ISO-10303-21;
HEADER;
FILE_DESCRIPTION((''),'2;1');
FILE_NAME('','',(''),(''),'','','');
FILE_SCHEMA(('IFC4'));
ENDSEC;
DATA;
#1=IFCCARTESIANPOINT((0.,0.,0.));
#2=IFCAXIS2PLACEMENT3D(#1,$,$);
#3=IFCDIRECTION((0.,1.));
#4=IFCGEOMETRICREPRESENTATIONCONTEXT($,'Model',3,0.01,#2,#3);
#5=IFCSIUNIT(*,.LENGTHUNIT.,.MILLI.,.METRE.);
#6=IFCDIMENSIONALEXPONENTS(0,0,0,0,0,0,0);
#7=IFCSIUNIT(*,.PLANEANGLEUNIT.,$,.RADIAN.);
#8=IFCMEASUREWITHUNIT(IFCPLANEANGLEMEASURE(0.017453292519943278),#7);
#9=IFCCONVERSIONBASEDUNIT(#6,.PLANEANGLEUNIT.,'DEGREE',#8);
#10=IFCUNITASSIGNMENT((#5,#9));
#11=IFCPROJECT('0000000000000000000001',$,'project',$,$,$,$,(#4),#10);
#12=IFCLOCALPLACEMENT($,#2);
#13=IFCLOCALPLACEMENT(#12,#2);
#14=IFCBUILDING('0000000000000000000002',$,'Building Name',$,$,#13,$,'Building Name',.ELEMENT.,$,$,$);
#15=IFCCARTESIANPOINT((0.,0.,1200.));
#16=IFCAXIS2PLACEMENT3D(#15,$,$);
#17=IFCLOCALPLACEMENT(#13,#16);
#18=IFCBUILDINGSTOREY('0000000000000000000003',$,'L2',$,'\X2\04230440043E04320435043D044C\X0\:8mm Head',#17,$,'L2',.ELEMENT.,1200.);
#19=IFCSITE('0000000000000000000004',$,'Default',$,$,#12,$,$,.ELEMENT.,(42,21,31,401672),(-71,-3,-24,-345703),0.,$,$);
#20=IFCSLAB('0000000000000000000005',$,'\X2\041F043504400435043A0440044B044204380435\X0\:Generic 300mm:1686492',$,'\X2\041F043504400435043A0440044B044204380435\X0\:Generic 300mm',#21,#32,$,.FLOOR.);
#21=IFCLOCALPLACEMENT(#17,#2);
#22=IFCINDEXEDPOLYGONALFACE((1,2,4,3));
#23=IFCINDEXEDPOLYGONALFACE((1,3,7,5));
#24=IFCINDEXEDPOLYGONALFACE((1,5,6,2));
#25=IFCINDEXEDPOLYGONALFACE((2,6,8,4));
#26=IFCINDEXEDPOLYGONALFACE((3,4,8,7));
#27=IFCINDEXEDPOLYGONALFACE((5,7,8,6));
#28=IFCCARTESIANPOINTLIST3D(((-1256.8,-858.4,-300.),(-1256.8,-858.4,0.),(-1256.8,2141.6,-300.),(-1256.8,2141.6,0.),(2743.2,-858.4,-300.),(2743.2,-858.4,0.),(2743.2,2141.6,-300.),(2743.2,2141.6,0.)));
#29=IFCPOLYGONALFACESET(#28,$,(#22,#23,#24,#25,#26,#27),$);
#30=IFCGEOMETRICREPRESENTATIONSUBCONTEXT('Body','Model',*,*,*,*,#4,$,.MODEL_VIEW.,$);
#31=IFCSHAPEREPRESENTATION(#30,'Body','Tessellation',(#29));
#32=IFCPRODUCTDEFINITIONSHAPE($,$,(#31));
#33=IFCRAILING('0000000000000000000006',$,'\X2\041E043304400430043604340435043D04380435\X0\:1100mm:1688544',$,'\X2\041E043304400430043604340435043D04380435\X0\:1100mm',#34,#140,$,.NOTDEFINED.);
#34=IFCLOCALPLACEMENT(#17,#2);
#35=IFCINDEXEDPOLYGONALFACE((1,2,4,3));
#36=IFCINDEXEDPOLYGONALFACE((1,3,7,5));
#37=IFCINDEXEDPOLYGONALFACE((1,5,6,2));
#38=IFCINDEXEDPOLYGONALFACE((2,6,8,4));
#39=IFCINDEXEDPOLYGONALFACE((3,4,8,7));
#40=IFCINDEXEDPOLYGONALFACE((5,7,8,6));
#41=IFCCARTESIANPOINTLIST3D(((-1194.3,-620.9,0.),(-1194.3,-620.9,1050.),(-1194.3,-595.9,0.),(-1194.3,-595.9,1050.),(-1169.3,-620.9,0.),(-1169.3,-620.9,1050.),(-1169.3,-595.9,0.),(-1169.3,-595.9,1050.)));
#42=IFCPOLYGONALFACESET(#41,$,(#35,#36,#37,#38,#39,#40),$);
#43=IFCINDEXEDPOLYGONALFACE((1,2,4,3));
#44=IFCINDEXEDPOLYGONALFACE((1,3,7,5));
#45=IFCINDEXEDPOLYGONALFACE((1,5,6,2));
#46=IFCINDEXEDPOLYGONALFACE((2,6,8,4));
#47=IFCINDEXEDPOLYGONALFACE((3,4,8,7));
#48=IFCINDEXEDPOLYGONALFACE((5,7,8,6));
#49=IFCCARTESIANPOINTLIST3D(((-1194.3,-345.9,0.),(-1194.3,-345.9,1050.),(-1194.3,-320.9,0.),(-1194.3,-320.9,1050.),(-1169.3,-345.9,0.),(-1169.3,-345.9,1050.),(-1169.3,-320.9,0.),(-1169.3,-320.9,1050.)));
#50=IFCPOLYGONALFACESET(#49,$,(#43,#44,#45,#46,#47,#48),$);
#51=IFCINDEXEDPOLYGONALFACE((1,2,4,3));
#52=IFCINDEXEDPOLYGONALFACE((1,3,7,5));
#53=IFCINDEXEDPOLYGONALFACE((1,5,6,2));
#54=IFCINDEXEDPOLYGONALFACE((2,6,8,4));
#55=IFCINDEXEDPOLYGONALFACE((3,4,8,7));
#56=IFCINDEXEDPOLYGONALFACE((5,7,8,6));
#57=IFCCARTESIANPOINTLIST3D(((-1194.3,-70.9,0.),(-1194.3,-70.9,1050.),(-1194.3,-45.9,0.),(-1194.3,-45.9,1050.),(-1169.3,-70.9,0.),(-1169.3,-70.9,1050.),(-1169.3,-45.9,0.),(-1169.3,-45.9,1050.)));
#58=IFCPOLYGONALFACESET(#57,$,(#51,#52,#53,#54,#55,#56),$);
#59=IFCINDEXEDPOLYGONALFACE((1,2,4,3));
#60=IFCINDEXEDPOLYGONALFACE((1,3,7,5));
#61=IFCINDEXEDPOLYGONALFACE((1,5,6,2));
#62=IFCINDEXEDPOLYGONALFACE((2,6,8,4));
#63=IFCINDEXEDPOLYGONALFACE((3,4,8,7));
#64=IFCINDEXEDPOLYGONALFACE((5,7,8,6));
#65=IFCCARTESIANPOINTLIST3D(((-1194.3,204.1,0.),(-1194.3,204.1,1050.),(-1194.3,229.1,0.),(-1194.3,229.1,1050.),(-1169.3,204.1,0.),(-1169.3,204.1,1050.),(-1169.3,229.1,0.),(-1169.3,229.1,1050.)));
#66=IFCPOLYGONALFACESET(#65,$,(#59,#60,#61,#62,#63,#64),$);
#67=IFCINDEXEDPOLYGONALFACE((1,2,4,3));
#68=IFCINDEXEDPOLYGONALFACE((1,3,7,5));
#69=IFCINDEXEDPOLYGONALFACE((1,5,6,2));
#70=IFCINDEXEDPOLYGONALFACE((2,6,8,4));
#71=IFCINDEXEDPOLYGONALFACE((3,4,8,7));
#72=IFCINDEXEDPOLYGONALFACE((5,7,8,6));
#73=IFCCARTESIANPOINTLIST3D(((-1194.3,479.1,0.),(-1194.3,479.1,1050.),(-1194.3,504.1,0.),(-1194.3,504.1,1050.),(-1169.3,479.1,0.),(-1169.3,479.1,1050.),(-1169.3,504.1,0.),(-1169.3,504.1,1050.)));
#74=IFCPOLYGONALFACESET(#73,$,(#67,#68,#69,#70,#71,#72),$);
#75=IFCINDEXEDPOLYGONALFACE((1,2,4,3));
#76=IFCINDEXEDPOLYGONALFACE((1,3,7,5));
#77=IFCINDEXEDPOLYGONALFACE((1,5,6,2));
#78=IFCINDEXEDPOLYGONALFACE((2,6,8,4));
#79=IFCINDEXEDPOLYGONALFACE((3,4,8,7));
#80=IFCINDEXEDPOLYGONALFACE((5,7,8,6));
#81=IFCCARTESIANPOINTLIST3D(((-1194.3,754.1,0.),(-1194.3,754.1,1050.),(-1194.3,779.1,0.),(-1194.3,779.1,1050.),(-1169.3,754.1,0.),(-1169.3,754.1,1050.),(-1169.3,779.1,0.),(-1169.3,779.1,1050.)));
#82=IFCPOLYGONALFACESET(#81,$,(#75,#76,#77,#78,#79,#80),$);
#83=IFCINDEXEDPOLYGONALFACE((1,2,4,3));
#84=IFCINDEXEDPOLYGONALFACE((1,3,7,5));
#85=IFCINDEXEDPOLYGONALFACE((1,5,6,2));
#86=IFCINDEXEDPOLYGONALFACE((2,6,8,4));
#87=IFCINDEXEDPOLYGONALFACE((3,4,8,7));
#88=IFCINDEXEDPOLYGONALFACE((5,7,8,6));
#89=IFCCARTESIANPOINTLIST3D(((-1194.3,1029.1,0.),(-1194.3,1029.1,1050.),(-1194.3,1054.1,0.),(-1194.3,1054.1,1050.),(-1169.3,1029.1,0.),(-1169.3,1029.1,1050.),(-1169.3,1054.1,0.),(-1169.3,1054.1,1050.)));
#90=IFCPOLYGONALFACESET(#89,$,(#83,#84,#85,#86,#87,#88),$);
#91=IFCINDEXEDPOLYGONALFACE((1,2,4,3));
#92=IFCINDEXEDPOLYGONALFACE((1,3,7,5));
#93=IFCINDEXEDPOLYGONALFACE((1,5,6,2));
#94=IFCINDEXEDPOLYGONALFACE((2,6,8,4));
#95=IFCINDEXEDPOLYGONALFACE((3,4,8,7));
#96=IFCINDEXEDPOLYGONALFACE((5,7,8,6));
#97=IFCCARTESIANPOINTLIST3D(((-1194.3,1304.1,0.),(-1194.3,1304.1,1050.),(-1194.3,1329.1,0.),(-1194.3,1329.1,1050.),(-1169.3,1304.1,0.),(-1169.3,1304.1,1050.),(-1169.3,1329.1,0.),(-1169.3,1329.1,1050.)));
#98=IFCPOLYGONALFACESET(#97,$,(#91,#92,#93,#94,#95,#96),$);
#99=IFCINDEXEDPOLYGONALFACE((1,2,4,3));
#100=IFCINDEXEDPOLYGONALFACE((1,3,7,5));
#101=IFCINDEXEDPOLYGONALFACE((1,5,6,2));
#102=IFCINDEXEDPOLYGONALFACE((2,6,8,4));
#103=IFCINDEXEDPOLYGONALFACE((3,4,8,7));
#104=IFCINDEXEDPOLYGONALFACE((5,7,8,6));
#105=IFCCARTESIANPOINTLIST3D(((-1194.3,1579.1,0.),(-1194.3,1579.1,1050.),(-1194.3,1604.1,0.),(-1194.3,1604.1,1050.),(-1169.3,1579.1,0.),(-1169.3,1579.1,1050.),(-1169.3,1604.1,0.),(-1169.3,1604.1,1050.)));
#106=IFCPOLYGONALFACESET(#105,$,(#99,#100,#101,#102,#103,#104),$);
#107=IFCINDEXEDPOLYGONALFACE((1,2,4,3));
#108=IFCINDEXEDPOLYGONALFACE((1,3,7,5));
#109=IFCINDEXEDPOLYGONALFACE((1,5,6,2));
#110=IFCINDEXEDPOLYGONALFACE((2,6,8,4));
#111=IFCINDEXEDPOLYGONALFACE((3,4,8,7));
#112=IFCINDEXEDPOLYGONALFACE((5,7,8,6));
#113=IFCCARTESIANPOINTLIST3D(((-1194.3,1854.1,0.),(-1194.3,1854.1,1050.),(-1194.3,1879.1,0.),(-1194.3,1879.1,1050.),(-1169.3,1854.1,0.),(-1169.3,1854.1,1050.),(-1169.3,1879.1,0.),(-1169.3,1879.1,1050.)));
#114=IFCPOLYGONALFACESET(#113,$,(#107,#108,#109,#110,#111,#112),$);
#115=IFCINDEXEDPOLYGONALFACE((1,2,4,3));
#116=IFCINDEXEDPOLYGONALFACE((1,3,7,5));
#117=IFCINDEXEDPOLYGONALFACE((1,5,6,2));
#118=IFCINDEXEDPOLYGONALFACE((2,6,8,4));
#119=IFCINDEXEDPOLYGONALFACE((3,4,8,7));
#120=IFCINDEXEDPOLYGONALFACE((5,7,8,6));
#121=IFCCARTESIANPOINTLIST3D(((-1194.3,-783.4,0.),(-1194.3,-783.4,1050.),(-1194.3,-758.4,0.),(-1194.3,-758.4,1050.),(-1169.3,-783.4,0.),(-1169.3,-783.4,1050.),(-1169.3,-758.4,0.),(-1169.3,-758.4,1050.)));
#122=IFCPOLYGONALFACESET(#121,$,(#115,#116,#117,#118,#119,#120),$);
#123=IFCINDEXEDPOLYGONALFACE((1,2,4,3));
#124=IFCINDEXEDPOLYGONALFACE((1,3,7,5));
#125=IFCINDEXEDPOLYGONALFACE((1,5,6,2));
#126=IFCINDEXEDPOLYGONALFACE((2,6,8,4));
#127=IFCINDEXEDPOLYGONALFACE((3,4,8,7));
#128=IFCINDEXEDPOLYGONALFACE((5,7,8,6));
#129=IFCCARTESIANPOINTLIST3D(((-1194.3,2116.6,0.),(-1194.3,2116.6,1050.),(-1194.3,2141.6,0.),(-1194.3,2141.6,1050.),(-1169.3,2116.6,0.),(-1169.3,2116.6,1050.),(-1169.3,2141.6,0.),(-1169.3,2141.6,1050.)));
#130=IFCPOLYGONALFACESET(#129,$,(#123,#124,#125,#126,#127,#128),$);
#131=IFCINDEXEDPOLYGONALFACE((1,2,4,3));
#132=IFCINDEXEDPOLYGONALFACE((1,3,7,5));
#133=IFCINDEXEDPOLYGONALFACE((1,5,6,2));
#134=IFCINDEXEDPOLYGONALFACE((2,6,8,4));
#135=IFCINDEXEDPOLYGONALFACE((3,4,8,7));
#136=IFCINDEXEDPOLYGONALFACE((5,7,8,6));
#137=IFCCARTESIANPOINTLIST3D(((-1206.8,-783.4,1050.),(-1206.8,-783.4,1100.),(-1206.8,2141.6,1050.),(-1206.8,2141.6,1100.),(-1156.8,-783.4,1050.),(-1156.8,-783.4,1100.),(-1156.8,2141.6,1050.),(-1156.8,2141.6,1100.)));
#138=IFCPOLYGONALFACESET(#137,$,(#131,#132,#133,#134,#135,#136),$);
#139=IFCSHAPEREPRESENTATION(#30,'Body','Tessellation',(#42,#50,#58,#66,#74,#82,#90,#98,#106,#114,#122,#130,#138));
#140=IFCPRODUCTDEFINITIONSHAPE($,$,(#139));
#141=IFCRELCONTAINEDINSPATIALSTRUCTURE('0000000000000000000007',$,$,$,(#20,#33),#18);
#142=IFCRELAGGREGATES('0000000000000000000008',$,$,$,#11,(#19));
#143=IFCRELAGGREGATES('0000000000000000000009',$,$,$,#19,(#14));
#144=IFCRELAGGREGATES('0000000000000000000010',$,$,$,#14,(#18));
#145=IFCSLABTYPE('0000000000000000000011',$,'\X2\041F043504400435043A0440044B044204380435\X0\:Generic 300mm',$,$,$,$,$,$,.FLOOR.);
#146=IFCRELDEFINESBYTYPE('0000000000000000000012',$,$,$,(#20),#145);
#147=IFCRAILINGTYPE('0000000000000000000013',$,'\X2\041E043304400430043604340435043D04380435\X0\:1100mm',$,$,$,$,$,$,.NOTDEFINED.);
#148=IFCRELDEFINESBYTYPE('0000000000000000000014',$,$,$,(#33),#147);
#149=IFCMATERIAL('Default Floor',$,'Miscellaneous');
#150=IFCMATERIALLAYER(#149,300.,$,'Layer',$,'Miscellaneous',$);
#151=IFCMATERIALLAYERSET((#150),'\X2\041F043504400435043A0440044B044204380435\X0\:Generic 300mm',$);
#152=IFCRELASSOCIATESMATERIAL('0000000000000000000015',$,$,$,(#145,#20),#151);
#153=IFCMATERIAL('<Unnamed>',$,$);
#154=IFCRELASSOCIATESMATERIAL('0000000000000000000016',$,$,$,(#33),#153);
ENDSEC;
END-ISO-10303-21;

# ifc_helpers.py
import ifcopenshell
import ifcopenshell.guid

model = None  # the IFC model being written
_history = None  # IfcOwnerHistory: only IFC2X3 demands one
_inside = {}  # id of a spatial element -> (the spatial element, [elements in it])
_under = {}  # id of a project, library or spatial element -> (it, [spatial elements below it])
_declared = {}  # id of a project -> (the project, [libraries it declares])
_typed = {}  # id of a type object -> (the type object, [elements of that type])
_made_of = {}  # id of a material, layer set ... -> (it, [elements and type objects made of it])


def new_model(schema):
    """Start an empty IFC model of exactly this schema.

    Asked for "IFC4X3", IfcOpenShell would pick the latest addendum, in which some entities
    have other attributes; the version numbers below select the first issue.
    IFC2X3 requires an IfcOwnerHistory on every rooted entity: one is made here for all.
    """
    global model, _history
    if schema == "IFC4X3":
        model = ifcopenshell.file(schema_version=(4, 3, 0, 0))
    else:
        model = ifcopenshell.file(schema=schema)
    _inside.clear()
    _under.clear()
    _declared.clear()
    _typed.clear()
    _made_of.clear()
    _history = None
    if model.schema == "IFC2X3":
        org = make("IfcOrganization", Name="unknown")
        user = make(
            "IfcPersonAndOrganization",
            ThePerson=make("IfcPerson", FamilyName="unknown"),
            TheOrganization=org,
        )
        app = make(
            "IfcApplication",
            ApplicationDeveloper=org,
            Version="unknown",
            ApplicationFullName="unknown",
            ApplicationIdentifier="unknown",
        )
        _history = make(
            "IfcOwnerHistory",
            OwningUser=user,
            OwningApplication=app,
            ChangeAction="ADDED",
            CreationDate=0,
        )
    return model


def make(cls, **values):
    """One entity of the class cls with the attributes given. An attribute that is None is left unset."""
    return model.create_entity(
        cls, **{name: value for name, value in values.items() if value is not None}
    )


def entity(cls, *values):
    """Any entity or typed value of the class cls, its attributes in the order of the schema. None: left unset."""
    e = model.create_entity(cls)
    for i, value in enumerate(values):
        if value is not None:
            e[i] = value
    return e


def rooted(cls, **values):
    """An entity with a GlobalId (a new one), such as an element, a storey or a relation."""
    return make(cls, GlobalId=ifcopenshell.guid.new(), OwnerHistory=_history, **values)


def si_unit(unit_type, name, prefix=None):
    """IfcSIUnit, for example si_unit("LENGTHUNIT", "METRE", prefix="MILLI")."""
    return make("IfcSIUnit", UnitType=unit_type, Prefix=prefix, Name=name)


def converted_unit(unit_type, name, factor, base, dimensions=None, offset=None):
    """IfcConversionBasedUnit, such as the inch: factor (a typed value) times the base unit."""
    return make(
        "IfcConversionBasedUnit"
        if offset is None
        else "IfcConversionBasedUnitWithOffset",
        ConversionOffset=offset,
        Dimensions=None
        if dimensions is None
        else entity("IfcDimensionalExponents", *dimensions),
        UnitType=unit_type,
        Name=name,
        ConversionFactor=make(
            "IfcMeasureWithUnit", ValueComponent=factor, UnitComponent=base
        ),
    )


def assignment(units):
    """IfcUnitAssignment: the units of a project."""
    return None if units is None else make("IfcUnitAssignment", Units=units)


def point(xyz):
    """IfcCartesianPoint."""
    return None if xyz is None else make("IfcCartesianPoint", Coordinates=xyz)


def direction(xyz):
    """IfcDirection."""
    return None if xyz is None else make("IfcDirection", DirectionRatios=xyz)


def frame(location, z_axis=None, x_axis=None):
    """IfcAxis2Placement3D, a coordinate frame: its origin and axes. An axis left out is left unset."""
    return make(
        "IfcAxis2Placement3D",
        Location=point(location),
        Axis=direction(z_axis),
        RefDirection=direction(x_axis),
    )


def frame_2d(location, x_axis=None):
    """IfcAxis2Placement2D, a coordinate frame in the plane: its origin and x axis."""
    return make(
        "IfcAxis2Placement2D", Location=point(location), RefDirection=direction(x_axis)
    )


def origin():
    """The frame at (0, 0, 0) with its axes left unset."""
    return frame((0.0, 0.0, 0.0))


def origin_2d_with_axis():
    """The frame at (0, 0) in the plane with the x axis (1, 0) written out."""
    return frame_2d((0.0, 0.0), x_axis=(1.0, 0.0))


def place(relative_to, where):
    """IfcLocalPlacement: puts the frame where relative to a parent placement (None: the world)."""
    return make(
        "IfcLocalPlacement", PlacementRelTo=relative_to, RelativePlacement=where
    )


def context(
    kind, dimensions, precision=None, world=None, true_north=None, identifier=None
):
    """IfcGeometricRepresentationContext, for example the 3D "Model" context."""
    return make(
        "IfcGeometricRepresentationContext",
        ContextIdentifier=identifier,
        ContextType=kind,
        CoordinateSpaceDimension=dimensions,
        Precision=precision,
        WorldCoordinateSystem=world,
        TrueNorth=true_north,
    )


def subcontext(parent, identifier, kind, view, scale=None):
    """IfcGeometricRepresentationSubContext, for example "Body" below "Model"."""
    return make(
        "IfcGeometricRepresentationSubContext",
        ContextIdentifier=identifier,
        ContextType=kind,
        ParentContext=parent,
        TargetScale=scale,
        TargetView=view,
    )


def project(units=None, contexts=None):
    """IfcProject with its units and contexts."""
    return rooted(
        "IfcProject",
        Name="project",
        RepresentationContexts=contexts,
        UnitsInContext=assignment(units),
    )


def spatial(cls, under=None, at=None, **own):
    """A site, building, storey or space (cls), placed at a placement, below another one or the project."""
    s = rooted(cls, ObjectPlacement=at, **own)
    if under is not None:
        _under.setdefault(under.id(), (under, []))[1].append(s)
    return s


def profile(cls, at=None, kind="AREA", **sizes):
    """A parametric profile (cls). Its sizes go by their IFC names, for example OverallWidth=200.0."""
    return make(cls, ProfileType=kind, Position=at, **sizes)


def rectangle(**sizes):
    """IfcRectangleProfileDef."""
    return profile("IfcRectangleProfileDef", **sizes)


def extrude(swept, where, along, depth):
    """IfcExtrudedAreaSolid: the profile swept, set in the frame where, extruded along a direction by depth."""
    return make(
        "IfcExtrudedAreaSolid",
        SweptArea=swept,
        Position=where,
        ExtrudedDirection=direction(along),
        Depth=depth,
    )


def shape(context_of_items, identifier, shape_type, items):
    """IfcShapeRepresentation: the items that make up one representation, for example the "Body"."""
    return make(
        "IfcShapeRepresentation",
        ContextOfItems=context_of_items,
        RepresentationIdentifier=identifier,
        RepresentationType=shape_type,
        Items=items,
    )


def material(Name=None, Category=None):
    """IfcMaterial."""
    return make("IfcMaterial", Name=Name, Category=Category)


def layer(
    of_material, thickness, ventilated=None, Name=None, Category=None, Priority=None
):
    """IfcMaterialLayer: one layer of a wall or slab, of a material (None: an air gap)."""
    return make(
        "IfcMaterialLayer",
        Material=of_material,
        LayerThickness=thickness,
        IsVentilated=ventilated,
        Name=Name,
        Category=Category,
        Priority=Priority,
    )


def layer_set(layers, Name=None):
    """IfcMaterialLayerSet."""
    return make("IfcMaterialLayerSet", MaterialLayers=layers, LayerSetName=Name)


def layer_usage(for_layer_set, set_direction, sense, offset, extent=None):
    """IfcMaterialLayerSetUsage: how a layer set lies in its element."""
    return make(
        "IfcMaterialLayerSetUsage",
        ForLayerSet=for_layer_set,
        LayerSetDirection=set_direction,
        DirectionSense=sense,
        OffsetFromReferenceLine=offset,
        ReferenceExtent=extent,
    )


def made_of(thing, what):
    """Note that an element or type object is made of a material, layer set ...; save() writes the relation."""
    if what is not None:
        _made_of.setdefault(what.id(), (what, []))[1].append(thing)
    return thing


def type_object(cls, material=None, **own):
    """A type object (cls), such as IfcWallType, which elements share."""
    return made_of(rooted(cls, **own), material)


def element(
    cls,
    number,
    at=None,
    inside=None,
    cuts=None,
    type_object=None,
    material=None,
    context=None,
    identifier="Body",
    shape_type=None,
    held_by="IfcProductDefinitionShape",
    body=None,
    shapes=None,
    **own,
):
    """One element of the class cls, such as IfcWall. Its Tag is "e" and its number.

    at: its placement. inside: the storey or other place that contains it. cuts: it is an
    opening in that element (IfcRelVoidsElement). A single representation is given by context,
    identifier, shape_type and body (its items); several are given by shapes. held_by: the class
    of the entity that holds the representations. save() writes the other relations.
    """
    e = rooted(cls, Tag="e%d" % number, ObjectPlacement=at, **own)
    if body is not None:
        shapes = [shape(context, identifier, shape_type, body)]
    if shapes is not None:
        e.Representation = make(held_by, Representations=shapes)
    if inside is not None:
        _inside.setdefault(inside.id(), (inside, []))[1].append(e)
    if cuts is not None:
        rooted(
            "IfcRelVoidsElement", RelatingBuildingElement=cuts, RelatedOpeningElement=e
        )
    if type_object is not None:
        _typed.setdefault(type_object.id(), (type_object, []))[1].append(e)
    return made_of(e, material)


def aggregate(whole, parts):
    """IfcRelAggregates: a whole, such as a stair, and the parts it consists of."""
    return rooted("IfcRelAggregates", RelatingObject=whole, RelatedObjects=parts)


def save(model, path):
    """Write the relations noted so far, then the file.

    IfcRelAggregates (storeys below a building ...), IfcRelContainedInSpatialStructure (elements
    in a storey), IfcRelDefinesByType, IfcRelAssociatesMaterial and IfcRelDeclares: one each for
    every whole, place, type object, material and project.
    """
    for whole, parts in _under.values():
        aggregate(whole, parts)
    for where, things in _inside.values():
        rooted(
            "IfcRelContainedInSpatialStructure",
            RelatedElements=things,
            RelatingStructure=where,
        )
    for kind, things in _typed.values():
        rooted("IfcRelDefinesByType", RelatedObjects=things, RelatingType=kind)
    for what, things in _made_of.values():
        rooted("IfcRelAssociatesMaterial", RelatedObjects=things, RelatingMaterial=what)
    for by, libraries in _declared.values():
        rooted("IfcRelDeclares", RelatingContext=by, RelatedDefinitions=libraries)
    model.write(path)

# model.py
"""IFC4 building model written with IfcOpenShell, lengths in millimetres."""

from ifc_helpers import new_model, entity, si_unit, converted_unit, direction, frame, frame_2d, origin, origin_2d_with_axis, place, context, subcontext, project, spatial, rectangle, extrude, material, layer, layer_set, layer_usage, type_object, element, save


model = new_model("IFC4")

# Units and contexts
model_context = context("Model", 3, precision=0.01, world=origin(), true_north=direction((0.0, 1.0)))
body_context = subcontext(model_context, "Body", "Model", "MODEL_VIEW")
ifc_project = project(units=[si_unit("LENGTHUNIT", "METRE", prefix="MILLI"), converted_unit("PLANEANGLEUNIT", "DEGREE", entity("IfcPlaneAngleMeasure", 0.017453292519943278), si_unit("PLANEANGLEUNIT", "RADIAN"), dimensions=[0, 0, 0, 0, 0, 0, 0])], contexts=[model_context])

# Site, building, storey
site_placement = place(None, origin())
site = spatial("IfcSite", under=ifc_project, at=site_placement, Name="Default", CompositionType="ELEMENT", RefLatitude=(42, 21, 31, 401672), RefLongitude=(-71, -3, -24, -345703), RefElevation=0.0)
building_placement = place(site_placement, origin())
building = spatial("IfcBuilding", under=site, at=building_placement, Name="Building Name", LongName="Building Name", CompositionType="ELEMENT")
storey_placement = place(building_placement, frame((0.0, 0.0, 1200.0)))
storey = spatial("IfcBuildingStorey", under=building, at=storey_placement, Name="L2", ObjectType="Уровень:8mm Head", LongName="L2", CompositionType="ELEMENT", Elevation=1200.0)

# Slab
ifc_material_1 = material(Name="Default Floor", Category="Miscellaneous")
ifc_layer = layer(ifc_material_1, 300.0, Name="Layer", Category="Miscellaneous")
ifc_layer_set = layer_set([ifc_layer], Name="Перекрытие:Generic 300mm")
ifc_layer_usage = layer_usage(ifc_layer_set, "AXIS3", "POSITIVE", 0.0)
slab_type = type_object("IfcSlabType", Name="Перекрытие:Generic 300mm", PredefinedType="FLOOR", material=ifc_layer_set)
slab_placement = place(storey_placement, origin())
element("IfcSlab", 1, at=slab_placement, inside=storey, type_object=slab_type, material=ifc_layer_usage, Name="Перекрытие:Generic 300mm:1686492", ObjectType="Перекрытие:Generic 300mm", PredefinedType="FLOOR", context=body_context, shape_type="SweptSolid", body=[
    extrude(rectangle(XDim=3000.0, YDim=4000.0, at=origin_2d_with_axis()), frame((743.2, 641.6, 0.0), z_axis=(0.0, 0.0, -1.0), x_axis=(0.0, 1.0, 0.0)), (0.0, 0.0, 1.0), 300.0),
])

# Railing
ifc_material_2 = material(Name="<Unnamed>")
railing_type = type_object("IfcRailingType", Name="Ограждение:1100mm", PredefinedType="NOTDEFINED")
railing_1_placement = place(storey_placement, frame((-1206.8, -783.4, 0.0)))
element("IfcRailing", 2, at=railing_1_placement, inside=storey, type_object=railing_type, material=ifc_material_2, Name="Ограждение:1100mm:1688544", ObjectType="Ограждение:1100mm", PredefinedType="NOTDEFINED", context=body_context, shape_type="SweptSolid", body=[
    extrude(rectangle(XDim=25.0, YDim=25.0, at=frame_2d((0.0, 0.0), x_axis=(1.0, 0.0))), frame((25.0, 175.0, 0.0), z_axis=(0.0, 0.0, 1.0), x_axis=(0.0, -1.0, 0.0)), (0.0, 0.0, 1.0), 1050.0),
    extrude(rectangle(XDim=25.0, YDim=25.0, at=origin_2d_with_axis()), frame((25.0, 450.0, 0.0), z_axis=(0.0, 0.0, 1.0), x_axis=(0.0, -1.0, 0.0)), (0.0, 0.0, 1.0), 1050.0),
    extrude(rectangle(XDim=25.0, YDim=25.0, at=origin_2d_with_axis()), frame((25.0, 725.0, 0.0), z_axis=(0.0, 0.0, 1.0), x_axis=(0.0, -1.0, 0.0)), (0.0, 0.0, 1.0), 1050.0),
    extrude(rectangle(XDim=25.0, YDim=25.0, at=origin_2d_with_axis()), frame((25.0, 1000.0, 0.0), z_axis=(0.0, 0.0, 1.0), x_axis=(0.0, -1.0, 0.0)), (0.0, 0.0, 1.0), 1050.0),
    extrude(rectangle(XDim=25.0, YDim=25.0, at=origin_2d_with_axis()), frame((25.0, 1275.0, 0.0), z_axis=(0.0, 0.0, 1.0), x_axis=(0.0, -1.0, 0.0)), (0.0, 0.0, 1.0), 1050.0),
    extrude(rectangle(XDim=25.0, YDim=25.0, at=origin_2d_with_axis()), frame((25.0, 1550.0, 0.0), z_axis=(0.0, 0.0, 1.0), x_axis=(0.0, -1.0, 0.0)), (0.0, 0.0, 1.0), 1050.0),
    extrude(rectangle(XDim=25.0, YDim=25.0, at=frame_2d((0.0, 0.0), x_axis=(1.0, 0.0))), frame((25.0, 1825.0, 0.0), z_axis=(0.0, 0.0, 1.0), x_axis=(0.0, -1.0, 0.0)), (0.0, 0.0, 1.0), 1050.0),
    extrude(rectangle(XDim=25.0, YDim=25.0, at=origin_2d_with_axis()), frame((25.0, 2100.0, 0.0), z_axis=(0.0, 0.0, 1.0), x_axis=(0.0, -1.0, 0.0)), (0.0, 0.0, 1.0), 1050.0),
    extrude(rectangle(XDim=25.0, YDim=25.0, at=origin_2d_with_axis()), frame((25.0, 2375.0, 0.0), z_axis=(0.0, 0.0, 1.0), x_axis=(0.0, -1.0, 0.0)), (0.0, 0.0, 1.0), 1050.0),
    extrude(rectangle(XDim=25.0, YDim=25.0, at=origin_2d_with_axis()), frame((25.0, 2650.0, 0.0), z_axis=(0.0, 0.0, 1.0), x_axis=(0.0, -1.0, 0.0)), (0.0, 0.0, 1.0), 1050.0),
    extrude(rectangle(XDim=25.0, YDim=25.0, at=origin_2d_with_axis()), frame((25.0, 12.5, 0.0), z_axis=(0.0, 0.0, 1.0), x_axis=(0.0, -1.0, 0.0)), (0.0, 0.0, 1.0), 1050.0),
    extrude(rectangle(XDim=25.0, YDim=25.0, at=origin_2d_with_axis()), frame((25.0, 2912.5, 0.0), z_axis=(0.0, 0.0, 1.0), x_axis=(0.0, -1.0, 0.0)), (0.0, 0.0, 1.0), 1050.0),
    extrude(rectangle(XDim=2925.0, YDim=50.0, at=frame_2d((0.0, 0.0), x_axis=(1.0, 0.0))), frame((25.0, 1462.5, 1050.0), z_axis=(0.0, 0.0, 1.0), x_axis=(0.0, -1.0, 0.0)), (0.0, 0.0, 1.0), 50.0),
])

save(model, "model.ifc")
